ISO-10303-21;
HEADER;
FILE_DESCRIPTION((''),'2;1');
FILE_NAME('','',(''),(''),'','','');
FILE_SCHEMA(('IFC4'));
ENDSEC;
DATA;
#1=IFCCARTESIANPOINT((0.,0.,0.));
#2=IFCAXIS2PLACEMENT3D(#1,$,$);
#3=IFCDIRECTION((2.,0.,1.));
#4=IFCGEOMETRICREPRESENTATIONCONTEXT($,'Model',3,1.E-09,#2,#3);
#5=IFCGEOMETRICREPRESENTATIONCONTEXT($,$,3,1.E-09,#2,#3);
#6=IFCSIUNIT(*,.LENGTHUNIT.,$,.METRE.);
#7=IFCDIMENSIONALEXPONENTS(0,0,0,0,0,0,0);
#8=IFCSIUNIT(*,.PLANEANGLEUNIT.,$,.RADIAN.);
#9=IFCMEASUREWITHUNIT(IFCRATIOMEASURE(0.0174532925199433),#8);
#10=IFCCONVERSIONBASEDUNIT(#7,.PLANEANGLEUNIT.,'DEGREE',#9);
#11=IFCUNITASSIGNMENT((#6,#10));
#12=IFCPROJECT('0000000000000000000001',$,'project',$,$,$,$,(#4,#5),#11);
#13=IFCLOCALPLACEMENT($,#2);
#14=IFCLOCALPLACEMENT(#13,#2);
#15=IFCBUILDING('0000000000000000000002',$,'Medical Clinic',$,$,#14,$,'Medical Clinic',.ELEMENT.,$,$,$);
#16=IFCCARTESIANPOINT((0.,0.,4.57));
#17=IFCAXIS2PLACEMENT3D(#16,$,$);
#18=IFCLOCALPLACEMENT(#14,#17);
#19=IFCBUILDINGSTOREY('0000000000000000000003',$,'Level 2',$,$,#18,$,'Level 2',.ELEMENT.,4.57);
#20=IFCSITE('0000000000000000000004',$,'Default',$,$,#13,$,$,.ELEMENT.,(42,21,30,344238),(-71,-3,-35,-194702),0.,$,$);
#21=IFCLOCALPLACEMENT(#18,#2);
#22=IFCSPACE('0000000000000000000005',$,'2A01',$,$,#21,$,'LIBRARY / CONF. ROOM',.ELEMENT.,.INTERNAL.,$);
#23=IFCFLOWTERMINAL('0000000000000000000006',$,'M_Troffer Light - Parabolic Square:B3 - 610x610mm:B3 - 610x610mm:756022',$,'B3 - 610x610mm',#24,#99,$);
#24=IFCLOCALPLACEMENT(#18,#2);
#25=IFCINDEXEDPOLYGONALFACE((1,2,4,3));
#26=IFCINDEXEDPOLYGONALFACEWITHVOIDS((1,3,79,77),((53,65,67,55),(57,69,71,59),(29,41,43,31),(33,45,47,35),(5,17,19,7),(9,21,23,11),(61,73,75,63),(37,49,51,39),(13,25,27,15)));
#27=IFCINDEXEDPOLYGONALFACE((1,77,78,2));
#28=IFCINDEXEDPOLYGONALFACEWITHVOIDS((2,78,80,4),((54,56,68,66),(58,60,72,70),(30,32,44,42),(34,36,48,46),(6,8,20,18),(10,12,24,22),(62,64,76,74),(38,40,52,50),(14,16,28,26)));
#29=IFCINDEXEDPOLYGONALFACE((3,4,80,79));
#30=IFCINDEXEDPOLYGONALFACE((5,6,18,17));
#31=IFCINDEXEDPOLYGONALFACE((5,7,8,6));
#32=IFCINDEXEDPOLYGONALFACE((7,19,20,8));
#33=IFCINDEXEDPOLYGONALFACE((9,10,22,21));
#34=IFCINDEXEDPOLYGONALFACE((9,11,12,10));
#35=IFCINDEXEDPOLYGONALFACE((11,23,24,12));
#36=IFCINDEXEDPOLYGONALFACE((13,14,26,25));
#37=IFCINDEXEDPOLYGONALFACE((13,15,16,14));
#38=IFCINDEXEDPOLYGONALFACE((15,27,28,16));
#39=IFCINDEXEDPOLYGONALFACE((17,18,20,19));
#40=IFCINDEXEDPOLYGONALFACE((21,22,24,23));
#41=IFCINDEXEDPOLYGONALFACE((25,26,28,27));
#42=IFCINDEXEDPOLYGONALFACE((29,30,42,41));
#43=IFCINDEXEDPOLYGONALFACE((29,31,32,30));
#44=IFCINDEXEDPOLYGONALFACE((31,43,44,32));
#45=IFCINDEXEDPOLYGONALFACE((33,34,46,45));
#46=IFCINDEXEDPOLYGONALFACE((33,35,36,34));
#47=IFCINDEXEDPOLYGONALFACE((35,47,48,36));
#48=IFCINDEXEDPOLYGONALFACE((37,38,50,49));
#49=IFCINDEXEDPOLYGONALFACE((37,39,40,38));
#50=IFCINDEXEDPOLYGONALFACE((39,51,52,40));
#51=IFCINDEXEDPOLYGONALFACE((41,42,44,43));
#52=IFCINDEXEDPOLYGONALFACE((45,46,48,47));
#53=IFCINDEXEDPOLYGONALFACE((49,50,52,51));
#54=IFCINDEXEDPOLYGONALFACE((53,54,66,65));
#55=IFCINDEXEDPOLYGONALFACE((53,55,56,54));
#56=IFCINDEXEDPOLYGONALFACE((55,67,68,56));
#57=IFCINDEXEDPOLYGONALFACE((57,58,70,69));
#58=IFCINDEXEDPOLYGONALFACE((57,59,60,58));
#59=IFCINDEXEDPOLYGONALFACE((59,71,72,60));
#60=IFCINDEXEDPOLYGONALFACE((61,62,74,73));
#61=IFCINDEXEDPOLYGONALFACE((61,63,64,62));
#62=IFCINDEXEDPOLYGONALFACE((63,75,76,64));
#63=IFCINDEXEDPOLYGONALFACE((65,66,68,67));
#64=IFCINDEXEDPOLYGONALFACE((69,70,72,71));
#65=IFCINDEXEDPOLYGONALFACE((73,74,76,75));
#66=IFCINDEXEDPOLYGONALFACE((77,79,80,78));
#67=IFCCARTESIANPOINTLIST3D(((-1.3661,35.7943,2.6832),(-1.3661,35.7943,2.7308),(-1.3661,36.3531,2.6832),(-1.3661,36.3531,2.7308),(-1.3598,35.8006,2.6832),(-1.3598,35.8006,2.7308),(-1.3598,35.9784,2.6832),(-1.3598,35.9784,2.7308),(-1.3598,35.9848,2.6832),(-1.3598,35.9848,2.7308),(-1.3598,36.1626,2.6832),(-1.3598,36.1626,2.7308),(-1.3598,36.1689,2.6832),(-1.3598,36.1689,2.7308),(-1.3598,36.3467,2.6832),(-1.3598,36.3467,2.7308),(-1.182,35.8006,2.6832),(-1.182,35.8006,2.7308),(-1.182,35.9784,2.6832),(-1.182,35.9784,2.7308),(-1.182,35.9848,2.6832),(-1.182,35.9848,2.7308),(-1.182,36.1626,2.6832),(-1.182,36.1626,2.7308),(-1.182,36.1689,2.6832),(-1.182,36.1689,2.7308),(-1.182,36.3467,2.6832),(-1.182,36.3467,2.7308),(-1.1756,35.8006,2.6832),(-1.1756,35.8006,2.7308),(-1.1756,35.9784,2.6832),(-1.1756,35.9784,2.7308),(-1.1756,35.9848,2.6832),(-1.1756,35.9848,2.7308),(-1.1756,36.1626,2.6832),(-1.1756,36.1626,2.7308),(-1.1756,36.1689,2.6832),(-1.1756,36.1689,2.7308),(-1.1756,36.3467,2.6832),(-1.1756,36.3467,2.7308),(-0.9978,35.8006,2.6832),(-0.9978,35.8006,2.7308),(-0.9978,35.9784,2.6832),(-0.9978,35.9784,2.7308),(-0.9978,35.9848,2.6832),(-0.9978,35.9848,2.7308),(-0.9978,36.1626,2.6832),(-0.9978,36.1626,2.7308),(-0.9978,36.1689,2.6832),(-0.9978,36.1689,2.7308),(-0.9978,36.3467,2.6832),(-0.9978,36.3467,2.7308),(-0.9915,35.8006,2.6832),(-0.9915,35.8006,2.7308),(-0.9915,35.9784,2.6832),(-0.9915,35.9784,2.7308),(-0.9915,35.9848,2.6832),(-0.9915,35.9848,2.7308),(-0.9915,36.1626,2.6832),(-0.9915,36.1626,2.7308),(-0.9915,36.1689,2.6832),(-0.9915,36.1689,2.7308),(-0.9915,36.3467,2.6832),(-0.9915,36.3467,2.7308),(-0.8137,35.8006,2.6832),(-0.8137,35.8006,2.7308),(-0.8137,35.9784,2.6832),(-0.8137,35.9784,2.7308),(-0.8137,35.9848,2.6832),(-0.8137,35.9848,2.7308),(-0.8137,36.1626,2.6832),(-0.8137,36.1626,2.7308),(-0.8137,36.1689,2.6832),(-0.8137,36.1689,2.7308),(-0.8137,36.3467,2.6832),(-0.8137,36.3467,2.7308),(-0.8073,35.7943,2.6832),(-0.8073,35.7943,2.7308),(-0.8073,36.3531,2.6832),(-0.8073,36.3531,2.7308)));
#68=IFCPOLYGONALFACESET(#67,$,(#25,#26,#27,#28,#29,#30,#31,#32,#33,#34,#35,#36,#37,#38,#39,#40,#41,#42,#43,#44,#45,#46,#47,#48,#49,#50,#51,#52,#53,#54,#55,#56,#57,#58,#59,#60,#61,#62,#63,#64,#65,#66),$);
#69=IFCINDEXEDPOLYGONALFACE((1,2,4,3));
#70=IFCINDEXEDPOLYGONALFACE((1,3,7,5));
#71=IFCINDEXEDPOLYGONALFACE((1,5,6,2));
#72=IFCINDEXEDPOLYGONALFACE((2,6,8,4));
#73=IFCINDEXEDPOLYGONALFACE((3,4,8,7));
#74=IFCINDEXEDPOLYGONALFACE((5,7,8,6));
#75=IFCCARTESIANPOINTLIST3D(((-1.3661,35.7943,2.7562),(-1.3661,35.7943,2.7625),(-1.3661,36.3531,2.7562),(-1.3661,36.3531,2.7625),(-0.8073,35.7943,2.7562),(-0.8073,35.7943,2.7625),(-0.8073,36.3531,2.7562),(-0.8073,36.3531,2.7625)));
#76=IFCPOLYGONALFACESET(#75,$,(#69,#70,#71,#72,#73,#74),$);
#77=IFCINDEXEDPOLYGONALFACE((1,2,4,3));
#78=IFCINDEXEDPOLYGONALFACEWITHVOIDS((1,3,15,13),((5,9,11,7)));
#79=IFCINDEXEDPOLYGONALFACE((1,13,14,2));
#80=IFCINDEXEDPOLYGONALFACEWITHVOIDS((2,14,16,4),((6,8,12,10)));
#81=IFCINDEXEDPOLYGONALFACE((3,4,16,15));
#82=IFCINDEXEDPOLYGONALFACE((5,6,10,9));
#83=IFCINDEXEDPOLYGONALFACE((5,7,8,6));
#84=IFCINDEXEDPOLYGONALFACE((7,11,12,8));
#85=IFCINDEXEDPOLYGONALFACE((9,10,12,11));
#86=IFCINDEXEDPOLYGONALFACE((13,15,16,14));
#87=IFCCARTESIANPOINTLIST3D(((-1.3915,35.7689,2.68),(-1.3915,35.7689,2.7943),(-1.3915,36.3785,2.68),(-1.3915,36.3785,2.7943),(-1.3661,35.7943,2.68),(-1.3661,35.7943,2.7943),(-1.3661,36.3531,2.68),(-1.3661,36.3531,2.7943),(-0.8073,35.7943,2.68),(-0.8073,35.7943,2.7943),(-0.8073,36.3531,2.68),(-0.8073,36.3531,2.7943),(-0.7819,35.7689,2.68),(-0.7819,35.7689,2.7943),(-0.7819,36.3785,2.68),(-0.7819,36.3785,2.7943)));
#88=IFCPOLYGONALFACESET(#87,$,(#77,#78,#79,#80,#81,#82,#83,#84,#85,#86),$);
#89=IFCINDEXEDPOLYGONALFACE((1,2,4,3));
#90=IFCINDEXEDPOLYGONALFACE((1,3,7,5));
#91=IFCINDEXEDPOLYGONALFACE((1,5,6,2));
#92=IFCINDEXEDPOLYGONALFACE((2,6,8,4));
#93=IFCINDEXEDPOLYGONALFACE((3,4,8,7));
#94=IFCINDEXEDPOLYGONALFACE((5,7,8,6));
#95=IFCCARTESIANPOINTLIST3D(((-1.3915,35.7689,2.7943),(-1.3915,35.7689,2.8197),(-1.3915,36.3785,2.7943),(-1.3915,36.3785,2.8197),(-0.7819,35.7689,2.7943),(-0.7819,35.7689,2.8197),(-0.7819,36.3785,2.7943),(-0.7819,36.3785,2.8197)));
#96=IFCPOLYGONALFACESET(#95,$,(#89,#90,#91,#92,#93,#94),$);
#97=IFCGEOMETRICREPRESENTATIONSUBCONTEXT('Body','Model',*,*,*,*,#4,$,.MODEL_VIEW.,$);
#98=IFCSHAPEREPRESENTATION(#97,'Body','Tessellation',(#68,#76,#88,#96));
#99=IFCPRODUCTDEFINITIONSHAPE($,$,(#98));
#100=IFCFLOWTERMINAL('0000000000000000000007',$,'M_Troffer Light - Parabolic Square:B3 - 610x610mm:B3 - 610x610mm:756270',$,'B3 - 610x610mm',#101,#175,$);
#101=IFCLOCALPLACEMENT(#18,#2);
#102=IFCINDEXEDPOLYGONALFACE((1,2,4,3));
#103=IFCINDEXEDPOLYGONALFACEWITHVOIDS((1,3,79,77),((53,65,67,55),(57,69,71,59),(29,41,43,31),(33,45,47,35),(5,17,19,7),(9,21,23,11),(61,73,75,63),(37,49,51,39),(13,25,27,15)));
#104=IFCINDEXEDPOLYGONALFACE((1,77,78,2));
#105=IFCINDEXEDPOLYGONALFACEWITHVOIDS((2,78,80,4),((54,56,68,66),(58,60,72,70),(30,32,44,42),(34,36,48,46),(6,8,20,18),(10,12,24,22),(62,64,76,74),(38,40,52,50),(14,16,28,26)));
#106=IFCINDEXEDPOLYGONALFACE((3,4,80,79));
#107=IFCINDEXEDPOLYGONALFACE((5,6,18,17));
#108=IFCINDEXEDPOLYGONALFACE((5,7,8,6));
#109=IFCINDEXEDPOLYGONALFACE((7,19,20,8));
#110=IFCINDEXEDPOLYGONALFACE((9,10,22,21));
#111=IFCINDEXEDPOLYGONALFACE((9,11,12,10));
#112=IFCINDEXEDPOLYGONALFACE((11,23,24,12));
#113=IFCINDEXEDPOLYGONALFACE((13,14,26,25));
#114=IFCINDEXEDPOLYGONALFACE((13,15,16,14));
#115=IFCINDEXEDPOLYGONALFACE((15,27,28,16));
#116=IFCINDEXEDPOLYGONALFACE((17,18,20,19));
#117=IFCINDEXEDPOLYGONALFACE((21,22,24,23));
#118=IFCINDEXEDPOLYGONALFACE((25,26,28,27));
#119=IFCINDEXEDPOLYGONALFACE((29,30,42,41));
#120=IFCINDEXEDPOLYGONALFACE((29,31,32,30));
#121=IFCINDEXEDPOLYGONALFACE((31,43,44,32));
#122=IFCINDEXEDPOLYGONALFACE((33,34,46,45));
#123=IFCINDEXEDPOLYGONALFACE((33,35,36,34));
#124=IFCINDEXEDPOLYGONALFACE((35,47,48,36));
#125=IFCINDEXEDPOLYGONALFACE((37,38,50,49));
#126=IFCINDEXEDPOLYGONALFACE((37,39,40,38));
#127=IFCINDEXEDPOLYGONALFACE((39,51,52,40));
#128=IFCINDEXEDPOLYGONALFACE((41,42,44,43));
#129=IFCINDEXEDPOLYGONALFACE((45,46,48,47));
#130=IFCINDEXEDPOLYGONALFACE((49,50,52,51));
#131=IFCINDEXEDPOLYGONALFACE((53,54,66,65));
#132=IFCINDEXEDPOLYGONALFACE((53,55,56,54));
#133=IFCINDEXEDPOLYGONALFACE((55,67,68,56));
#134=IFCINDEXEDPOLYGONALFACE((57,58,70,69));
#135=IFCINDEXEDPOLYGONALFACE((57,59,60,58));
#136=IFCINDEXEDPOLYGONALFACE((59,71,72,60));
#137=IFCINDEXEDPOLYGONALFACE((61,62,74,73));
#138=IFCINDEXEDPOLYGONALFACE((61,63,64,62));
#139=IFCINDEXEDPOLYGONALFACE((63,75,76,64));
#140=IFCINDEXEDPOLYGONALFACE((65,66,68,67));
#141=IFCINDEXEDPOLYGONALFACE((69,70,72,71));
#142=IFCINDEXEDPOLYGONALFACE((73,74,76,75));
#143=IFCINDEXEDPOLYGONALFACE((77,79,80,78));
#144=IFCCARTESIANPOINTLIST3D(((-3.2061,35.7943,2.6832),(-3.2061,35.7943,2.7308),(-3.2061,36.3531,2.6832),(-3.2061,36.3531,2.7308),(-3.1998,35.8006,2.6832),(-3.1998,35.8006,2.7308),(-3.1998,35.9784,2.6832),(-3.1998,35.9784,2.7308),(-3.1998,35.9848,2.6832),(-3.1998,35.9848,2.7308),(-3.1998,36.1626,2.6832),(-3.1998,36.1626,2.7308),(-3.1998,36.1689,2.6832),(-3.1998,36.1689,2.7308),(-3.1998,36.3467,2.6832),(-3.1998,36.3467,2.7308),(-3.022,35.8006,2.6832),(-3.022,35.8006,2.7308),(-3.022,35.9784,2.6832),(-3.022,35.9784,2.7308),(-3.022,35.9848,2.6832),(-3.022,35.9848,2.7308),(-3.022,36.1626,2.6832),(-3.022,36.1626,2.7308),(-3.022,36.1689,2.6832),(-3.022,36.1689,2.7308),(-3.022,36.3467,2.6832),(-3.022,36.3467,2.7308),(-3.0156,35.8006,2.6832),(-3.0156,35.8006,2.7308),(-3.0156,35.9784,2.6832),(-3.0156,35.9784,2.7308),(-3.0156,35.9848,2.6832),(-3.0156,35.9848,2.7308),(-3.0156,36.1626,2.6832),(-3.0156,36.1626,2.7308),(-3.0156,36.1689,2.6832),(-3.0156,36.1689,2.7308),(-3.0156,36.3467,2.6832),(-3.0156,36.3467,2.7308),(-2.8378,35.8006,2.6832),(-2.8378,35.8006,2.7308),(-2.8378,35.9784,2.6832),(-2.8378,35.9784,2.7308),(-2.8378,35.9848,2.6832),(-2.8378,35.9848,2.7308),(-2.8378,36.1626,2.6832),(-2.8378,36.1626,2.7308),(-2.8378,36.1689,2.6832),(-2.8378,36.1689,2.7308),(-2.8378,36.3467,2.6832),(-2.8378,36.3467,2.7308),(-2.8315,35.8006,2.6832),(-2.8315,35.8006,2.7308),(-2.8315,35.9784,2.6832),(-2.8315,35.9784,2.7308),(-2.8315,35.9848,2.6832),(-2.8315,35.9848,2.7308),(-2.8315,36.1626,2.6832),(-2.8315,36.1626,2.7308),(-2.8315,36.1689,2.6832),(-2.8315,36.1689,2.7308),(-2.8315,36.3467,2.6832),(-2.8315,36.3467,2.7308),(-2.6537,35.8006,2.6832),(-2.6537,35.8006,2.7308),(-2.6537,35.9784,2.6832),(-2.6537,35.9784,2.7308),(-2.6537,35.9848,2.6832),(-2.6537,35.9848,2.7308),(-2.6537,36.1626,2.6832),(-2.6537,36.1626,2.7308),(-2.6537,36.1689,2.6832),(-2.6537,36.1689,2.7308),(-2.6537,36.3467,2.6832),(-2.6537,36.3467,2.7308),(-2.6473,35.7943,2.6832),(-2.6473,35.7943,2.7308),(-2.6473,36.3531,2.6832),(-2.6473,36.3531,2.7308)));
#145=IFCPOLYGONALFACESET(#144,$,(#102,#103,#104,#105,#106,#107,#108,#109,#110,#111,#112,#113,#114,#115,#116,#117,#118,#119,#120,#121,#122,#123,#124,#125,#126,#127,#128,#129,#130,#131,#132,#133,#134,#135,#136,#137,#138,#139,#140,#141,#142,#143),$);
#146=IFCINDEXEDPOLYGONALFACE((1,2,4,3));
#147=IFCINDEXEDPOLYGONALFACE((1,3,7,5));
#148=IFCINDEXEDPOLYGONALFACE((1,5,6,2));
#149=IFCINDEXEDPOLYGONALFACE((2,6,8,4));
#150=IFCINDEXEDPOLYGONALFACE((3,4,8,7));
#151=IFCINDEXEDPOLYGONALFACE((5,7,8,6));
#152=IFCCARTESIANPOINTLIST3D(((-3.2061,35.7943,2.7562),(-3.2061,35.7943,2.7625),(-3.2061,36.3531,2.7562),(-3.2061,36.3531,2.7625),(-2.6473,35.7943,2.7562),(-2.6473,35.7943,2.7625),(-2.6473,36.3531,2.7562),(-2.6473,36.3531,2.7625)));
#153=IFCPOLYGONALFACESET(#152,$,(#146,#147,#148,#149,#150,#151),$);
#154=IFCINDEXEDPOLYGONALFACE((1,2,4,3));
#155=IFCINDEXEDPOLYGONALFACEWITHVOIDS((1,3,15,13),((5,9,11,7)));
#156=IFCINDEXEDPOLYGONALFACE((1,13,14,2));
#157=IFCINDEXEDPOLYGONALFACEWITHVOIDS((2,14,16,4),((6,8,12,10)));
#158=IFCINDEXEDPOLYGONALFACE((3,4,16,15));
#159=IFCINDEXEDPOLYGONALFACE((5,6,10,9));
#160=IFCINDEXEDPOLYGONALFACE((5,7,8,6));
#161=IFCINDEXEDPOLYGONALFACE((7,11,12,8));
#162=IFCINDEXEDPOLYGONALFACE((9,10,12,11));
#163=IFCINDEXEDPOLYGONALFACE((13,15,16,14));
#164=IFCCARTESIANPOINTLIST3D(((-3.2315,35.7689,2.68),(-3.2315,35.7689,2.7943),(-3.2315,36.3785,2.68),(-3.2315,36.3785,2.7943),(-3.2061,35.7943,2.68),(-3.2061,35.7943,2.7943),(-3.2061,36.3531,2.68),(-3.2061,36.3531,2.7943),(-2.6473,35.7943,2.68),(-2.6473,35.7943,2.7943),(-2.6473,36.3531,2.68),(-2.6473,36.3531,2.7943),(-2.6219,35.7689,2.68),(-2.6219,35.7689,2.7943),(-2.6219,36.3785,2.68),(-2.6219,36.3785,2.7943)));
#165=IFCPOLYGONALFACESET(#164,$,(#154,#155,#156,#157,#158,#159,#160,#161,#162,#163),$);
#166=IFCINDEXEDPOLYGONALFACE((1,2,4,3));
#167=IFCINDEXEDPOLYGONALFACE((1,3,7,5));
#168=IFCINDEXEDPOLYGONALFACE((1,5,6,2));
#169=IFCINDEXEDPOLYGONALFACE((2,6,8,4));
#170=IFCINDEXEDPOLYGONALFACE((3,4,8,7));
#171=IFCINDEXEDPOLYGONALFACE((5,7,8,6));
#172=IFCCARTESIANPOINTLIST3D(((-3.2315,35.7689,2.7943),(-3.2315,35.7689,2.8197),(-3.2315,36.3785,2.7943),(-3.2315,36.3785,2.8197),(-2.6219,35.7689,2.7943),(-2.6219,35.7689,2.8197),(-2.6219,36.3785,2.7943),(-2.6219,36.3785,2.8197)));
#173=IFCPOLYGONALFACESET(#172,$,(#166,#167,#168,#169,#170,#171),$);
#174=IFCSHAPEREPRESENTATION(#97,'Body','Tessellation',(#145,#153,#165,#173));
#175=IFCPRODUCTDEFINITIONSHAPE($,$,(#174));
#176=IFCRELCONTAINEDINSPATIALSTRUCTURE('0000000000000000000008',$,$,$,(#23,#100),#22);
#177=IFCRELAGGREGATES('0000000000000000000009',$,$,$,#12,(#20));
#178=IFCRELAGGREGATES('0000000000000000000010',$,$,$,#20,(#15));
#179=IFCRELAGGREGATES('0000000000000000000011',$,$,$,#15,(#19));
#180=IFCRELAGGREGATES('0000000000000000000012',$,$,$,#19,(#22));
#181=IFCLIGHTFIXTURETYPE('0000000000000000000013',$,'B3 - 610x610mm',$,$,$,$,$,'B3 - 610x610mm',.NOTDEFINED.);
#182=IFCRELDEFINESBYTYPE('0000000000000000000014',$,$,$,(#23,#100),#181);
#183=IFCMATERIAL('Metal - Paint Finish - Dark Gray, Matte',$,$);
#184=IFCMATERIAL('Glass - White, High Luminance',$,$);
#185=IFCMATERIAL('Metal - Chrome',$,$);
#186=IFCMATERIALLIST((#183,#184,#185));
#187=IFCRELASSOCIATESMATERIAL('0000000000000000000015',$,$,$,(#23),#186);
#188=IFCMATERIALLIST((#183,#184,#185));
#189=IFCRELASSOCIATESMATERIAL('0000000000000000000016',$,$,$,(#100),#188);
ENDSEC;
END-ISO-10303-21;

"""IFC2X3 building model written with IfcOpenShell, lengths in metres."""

from ifc_helpers import new_model, entity, si_unit, converted_unit, direction, frame, origin, origin_2d_with_axis, place, context, subcontext, project, spatial, polyline, rectangle, outline, extrude, source, transform, mapped, material, material_list, type_object, type_shapes, element, save


model = new_model("IFC2X3")

# Units and contexts
model_context = context("Model", 3, precision=1e-09, world=origin(), true_north=direction((2.0, 0.0, 1.0)))
context_of_model = context(None, 3, precision=1e-09, world=origin(), true_north=direction((2.0, 0.0, 1.0)))
body_context = subcontext(model_context, "Body", "Model", "MODEL_VIEW")
ifc_project = project(units=[si_unit("LENGTHUNIT", "METRE"), converted_unit("PLANEANGLEUNIT", "DEGREE", entity("IfcRatioMeasure", 0.0174532925199433), si_unit("PLANEANGLEUNIT", "RADIAN"), dimensions=[0, 0, 0, 0, 0, 0, 0])], contexts=[model_context, context_of_model])

# Site, building, storey, space
site_placement = place(None, origin())
site = spatial("IfcSite", under=ifc_project, at=site_placement, Name="Default", CompositionType="ELEMENT", RefLatitude=(42, 21, 30, 344238), RefLongitude=(-71, -3, -35, -194702), RefElevation=0.0)
building_placement = place(site_placement, origin())
building = spatial("IfcBuilding", under=site, at=building_placement, Name="Medical Clinic", LongName="Medical Clinic", CompositionType="ELEMENT")
storey_placement = place(building_placement, frame((0.0, 0.0, 4.57)))
storey = spatial("IfcBuildingStorey", under=building, at=storey_placement, Name="Level 2", LongName="Level 2", CompositionType="ELEMENT", Elevation=4.57)
space_1_placement = place(storey_placement, origin())
space_1 = spatial("IfcSpace", under=storey, at=space_1_placement, Name="2A01", LongName="LIBRARY / CONF. ROOM", CompositionType="ELEMENT", InteriorOrExteriorSpace="INTERNAL")

# Flow terminals
ifc_material_1 = material(Name="Metal - Paint Finish - Dark Gray, Matte")
ifc_material_2 = material(Name="Glass - White, High Luminance")
ifc_material_3 = material(Name="Metal - Chrome")
ifc_material_list_1 = material_list([ifc_material_1, ifc_material_2, ifc_material_3])
light_fixture_type_1 = type_object("IfcLightFixtureType", Name="B3 - 610x610mm", ElementType="B3 - 610x610mm", PredefinedType="NOTDEFINED")
shared_shape_1 = source(origin(), body_context, "Body", "SweptSolid", [
    extrude(outline(polyline([(-0.2794, -0.2794), (0.2794, -0.2794), (0.2794, 0.2794), (-0.2794, 0.2794), (-0.2794, -0.2794)]), holes=[polyline([(-0.0952, 0.0953), (-0.273, 0.0953), (-0.273, 0.2731), (-0.0952, 0.2731), (-0.0952, 0.0953)]), polyline([(0.2731, 0.0953), (0.0953, 0.0953), (0.0953, 0.2731), (0.2731, 0.2731), (0.2731, 0.0953)]), polyline([(-0.0889, 0.2731), (0.0889, 0.2731), (0.0889, 0.0953), (-0.0889, 0.0953), (-0.0889, 0.2731)]), polyline([(0.2731, -0.273), (0.0953, -0.273), (0.0953, -0.0952), (0.2731, -0.0952), (0.2731, -0.273)]), polyline([(0.0889, -0.273), (-0.0889, -0.273), (-0.0889, -0.0952), (0.0889, -0.0952), (0.0889, -0.273)]), polyline([(-0.0952, -0.273), (-0.273, -0.273), (-0.273, -0.0952), (-0.0952, -0.0952), (-0.0952, -0.273)]), polyline([(-0.0952, -0.0889), (-0.273, -0.0889), (-0.273, 0.0889), (-0.0952, 0.0889), (-0.0952, -0.0889)]), polyline([(0.0889, -0.0889), (-0.0889, -0.0889), (-0.0889, 0.0889), (0.0889, 0.0889), (0.0889, -0.0889)]), polyline([(0.2731, -0.0889), (0.0953, -0.0889), (0.0953, 0.0889), (0.2731, 0.0889), (0.2731, -0.0889)])]), frame((0.0, -0.3048, -0.0508), z_axis=(0.0, 0.0, 1.0), x_axis=(-1.0, 0.0, 0.0)), (0.0, 0.0, 1.0), 0.0476),
    extrude(rectangle(XDim=0.5588, YDim=0.5588, at=origin_2d_with_axis()), frame((0.0, -0.3048, -0.0825), z_axis=(0.0, 0.0, 1.0), x_axis=(-1.0, 0.0, 0.0)), (0.0, 0.0, 1.0), 0.0064),
    extrude(outline(polyline([(-0.3048, -0.3048), (0.3048, -0.3048), (0.3048, 0.3048), (-0.3048, 0.3048), (-0.3048, -0.3048)]), holes=[polyline([(0.2794, 0.2794), (0.2794, -0.2794), (-0.2794, -0.2794), (-0.2794, 0.2794), (0.2794, 0.2794)])]), frame((0.0, -0.3048, -0.1143)), (0.0, 0.0, 1.0), 0.1143),
    extrude(rectangle(XDim=0.6096, YDim=0.6096, at=origin_2d_with_axis()), frame((0.0, -0.3048, -0.1397), z_axis=(0.0, 0.0, 1.0), x_axis=(-1.0, 0.0, 0.0)), (0.0, 0.0, 1.0), 0.0254),
])
type_shapes(light_fixture_type_1, [shared_shape_1])
flow_terminal_1_placement = place(space_1_placement, frame((-1.0867, 35.7689, 2.68), z_axis=(0.0, 0.0, -1.0), x_axis=(1.0, 0.0, 0.0)))
element("IfcFlowTerminal", 1, at=flow_terminal_1_placement, inside=space_1, type_object=light_fixture_type_1, material=ifc_material_list_1, Name="M_Troffer Light - Parabolic Square:B3 - 610x610mm:B3 - 610x610mm:756022", ObjectType="B3 - 610x610mm", context=body_context, shape_type="MappedRepresentation", body=[
    mapped(shared_shape_1, transform((0.0, 0.0, 0.0), scale=1.0)),
])
ifc_material_list_2 = material_list([ifc_material_1, ifc_material_2, ifc_material_3])
flow_terminal_2_placement = place(space_1_placement, frame((-2.9267, 35.7689, 2.68), z_axis=(0.0, 0.0, -1.0), x_axis=(1.0, 0.0, 0.0)))
element("IfcFlowTerminal", 2, at=flow_terminal_2_placement, inside=space_1, type_object=light_fixture_type_1, material=ifc_material_list_2, Name="M_Troffer Light - Parabolic Square:B3 - 610x610mm:B3 - 610x610mm:756270", ObjectType="B3 - 610x610mm", context=body_context, shape_type="MappedRepresentation", body=[
    mapped(shared_shape_1, transform((0.0, 0.0, 0.0), scale=1.0)),
])

save(model, "model.ifc")
